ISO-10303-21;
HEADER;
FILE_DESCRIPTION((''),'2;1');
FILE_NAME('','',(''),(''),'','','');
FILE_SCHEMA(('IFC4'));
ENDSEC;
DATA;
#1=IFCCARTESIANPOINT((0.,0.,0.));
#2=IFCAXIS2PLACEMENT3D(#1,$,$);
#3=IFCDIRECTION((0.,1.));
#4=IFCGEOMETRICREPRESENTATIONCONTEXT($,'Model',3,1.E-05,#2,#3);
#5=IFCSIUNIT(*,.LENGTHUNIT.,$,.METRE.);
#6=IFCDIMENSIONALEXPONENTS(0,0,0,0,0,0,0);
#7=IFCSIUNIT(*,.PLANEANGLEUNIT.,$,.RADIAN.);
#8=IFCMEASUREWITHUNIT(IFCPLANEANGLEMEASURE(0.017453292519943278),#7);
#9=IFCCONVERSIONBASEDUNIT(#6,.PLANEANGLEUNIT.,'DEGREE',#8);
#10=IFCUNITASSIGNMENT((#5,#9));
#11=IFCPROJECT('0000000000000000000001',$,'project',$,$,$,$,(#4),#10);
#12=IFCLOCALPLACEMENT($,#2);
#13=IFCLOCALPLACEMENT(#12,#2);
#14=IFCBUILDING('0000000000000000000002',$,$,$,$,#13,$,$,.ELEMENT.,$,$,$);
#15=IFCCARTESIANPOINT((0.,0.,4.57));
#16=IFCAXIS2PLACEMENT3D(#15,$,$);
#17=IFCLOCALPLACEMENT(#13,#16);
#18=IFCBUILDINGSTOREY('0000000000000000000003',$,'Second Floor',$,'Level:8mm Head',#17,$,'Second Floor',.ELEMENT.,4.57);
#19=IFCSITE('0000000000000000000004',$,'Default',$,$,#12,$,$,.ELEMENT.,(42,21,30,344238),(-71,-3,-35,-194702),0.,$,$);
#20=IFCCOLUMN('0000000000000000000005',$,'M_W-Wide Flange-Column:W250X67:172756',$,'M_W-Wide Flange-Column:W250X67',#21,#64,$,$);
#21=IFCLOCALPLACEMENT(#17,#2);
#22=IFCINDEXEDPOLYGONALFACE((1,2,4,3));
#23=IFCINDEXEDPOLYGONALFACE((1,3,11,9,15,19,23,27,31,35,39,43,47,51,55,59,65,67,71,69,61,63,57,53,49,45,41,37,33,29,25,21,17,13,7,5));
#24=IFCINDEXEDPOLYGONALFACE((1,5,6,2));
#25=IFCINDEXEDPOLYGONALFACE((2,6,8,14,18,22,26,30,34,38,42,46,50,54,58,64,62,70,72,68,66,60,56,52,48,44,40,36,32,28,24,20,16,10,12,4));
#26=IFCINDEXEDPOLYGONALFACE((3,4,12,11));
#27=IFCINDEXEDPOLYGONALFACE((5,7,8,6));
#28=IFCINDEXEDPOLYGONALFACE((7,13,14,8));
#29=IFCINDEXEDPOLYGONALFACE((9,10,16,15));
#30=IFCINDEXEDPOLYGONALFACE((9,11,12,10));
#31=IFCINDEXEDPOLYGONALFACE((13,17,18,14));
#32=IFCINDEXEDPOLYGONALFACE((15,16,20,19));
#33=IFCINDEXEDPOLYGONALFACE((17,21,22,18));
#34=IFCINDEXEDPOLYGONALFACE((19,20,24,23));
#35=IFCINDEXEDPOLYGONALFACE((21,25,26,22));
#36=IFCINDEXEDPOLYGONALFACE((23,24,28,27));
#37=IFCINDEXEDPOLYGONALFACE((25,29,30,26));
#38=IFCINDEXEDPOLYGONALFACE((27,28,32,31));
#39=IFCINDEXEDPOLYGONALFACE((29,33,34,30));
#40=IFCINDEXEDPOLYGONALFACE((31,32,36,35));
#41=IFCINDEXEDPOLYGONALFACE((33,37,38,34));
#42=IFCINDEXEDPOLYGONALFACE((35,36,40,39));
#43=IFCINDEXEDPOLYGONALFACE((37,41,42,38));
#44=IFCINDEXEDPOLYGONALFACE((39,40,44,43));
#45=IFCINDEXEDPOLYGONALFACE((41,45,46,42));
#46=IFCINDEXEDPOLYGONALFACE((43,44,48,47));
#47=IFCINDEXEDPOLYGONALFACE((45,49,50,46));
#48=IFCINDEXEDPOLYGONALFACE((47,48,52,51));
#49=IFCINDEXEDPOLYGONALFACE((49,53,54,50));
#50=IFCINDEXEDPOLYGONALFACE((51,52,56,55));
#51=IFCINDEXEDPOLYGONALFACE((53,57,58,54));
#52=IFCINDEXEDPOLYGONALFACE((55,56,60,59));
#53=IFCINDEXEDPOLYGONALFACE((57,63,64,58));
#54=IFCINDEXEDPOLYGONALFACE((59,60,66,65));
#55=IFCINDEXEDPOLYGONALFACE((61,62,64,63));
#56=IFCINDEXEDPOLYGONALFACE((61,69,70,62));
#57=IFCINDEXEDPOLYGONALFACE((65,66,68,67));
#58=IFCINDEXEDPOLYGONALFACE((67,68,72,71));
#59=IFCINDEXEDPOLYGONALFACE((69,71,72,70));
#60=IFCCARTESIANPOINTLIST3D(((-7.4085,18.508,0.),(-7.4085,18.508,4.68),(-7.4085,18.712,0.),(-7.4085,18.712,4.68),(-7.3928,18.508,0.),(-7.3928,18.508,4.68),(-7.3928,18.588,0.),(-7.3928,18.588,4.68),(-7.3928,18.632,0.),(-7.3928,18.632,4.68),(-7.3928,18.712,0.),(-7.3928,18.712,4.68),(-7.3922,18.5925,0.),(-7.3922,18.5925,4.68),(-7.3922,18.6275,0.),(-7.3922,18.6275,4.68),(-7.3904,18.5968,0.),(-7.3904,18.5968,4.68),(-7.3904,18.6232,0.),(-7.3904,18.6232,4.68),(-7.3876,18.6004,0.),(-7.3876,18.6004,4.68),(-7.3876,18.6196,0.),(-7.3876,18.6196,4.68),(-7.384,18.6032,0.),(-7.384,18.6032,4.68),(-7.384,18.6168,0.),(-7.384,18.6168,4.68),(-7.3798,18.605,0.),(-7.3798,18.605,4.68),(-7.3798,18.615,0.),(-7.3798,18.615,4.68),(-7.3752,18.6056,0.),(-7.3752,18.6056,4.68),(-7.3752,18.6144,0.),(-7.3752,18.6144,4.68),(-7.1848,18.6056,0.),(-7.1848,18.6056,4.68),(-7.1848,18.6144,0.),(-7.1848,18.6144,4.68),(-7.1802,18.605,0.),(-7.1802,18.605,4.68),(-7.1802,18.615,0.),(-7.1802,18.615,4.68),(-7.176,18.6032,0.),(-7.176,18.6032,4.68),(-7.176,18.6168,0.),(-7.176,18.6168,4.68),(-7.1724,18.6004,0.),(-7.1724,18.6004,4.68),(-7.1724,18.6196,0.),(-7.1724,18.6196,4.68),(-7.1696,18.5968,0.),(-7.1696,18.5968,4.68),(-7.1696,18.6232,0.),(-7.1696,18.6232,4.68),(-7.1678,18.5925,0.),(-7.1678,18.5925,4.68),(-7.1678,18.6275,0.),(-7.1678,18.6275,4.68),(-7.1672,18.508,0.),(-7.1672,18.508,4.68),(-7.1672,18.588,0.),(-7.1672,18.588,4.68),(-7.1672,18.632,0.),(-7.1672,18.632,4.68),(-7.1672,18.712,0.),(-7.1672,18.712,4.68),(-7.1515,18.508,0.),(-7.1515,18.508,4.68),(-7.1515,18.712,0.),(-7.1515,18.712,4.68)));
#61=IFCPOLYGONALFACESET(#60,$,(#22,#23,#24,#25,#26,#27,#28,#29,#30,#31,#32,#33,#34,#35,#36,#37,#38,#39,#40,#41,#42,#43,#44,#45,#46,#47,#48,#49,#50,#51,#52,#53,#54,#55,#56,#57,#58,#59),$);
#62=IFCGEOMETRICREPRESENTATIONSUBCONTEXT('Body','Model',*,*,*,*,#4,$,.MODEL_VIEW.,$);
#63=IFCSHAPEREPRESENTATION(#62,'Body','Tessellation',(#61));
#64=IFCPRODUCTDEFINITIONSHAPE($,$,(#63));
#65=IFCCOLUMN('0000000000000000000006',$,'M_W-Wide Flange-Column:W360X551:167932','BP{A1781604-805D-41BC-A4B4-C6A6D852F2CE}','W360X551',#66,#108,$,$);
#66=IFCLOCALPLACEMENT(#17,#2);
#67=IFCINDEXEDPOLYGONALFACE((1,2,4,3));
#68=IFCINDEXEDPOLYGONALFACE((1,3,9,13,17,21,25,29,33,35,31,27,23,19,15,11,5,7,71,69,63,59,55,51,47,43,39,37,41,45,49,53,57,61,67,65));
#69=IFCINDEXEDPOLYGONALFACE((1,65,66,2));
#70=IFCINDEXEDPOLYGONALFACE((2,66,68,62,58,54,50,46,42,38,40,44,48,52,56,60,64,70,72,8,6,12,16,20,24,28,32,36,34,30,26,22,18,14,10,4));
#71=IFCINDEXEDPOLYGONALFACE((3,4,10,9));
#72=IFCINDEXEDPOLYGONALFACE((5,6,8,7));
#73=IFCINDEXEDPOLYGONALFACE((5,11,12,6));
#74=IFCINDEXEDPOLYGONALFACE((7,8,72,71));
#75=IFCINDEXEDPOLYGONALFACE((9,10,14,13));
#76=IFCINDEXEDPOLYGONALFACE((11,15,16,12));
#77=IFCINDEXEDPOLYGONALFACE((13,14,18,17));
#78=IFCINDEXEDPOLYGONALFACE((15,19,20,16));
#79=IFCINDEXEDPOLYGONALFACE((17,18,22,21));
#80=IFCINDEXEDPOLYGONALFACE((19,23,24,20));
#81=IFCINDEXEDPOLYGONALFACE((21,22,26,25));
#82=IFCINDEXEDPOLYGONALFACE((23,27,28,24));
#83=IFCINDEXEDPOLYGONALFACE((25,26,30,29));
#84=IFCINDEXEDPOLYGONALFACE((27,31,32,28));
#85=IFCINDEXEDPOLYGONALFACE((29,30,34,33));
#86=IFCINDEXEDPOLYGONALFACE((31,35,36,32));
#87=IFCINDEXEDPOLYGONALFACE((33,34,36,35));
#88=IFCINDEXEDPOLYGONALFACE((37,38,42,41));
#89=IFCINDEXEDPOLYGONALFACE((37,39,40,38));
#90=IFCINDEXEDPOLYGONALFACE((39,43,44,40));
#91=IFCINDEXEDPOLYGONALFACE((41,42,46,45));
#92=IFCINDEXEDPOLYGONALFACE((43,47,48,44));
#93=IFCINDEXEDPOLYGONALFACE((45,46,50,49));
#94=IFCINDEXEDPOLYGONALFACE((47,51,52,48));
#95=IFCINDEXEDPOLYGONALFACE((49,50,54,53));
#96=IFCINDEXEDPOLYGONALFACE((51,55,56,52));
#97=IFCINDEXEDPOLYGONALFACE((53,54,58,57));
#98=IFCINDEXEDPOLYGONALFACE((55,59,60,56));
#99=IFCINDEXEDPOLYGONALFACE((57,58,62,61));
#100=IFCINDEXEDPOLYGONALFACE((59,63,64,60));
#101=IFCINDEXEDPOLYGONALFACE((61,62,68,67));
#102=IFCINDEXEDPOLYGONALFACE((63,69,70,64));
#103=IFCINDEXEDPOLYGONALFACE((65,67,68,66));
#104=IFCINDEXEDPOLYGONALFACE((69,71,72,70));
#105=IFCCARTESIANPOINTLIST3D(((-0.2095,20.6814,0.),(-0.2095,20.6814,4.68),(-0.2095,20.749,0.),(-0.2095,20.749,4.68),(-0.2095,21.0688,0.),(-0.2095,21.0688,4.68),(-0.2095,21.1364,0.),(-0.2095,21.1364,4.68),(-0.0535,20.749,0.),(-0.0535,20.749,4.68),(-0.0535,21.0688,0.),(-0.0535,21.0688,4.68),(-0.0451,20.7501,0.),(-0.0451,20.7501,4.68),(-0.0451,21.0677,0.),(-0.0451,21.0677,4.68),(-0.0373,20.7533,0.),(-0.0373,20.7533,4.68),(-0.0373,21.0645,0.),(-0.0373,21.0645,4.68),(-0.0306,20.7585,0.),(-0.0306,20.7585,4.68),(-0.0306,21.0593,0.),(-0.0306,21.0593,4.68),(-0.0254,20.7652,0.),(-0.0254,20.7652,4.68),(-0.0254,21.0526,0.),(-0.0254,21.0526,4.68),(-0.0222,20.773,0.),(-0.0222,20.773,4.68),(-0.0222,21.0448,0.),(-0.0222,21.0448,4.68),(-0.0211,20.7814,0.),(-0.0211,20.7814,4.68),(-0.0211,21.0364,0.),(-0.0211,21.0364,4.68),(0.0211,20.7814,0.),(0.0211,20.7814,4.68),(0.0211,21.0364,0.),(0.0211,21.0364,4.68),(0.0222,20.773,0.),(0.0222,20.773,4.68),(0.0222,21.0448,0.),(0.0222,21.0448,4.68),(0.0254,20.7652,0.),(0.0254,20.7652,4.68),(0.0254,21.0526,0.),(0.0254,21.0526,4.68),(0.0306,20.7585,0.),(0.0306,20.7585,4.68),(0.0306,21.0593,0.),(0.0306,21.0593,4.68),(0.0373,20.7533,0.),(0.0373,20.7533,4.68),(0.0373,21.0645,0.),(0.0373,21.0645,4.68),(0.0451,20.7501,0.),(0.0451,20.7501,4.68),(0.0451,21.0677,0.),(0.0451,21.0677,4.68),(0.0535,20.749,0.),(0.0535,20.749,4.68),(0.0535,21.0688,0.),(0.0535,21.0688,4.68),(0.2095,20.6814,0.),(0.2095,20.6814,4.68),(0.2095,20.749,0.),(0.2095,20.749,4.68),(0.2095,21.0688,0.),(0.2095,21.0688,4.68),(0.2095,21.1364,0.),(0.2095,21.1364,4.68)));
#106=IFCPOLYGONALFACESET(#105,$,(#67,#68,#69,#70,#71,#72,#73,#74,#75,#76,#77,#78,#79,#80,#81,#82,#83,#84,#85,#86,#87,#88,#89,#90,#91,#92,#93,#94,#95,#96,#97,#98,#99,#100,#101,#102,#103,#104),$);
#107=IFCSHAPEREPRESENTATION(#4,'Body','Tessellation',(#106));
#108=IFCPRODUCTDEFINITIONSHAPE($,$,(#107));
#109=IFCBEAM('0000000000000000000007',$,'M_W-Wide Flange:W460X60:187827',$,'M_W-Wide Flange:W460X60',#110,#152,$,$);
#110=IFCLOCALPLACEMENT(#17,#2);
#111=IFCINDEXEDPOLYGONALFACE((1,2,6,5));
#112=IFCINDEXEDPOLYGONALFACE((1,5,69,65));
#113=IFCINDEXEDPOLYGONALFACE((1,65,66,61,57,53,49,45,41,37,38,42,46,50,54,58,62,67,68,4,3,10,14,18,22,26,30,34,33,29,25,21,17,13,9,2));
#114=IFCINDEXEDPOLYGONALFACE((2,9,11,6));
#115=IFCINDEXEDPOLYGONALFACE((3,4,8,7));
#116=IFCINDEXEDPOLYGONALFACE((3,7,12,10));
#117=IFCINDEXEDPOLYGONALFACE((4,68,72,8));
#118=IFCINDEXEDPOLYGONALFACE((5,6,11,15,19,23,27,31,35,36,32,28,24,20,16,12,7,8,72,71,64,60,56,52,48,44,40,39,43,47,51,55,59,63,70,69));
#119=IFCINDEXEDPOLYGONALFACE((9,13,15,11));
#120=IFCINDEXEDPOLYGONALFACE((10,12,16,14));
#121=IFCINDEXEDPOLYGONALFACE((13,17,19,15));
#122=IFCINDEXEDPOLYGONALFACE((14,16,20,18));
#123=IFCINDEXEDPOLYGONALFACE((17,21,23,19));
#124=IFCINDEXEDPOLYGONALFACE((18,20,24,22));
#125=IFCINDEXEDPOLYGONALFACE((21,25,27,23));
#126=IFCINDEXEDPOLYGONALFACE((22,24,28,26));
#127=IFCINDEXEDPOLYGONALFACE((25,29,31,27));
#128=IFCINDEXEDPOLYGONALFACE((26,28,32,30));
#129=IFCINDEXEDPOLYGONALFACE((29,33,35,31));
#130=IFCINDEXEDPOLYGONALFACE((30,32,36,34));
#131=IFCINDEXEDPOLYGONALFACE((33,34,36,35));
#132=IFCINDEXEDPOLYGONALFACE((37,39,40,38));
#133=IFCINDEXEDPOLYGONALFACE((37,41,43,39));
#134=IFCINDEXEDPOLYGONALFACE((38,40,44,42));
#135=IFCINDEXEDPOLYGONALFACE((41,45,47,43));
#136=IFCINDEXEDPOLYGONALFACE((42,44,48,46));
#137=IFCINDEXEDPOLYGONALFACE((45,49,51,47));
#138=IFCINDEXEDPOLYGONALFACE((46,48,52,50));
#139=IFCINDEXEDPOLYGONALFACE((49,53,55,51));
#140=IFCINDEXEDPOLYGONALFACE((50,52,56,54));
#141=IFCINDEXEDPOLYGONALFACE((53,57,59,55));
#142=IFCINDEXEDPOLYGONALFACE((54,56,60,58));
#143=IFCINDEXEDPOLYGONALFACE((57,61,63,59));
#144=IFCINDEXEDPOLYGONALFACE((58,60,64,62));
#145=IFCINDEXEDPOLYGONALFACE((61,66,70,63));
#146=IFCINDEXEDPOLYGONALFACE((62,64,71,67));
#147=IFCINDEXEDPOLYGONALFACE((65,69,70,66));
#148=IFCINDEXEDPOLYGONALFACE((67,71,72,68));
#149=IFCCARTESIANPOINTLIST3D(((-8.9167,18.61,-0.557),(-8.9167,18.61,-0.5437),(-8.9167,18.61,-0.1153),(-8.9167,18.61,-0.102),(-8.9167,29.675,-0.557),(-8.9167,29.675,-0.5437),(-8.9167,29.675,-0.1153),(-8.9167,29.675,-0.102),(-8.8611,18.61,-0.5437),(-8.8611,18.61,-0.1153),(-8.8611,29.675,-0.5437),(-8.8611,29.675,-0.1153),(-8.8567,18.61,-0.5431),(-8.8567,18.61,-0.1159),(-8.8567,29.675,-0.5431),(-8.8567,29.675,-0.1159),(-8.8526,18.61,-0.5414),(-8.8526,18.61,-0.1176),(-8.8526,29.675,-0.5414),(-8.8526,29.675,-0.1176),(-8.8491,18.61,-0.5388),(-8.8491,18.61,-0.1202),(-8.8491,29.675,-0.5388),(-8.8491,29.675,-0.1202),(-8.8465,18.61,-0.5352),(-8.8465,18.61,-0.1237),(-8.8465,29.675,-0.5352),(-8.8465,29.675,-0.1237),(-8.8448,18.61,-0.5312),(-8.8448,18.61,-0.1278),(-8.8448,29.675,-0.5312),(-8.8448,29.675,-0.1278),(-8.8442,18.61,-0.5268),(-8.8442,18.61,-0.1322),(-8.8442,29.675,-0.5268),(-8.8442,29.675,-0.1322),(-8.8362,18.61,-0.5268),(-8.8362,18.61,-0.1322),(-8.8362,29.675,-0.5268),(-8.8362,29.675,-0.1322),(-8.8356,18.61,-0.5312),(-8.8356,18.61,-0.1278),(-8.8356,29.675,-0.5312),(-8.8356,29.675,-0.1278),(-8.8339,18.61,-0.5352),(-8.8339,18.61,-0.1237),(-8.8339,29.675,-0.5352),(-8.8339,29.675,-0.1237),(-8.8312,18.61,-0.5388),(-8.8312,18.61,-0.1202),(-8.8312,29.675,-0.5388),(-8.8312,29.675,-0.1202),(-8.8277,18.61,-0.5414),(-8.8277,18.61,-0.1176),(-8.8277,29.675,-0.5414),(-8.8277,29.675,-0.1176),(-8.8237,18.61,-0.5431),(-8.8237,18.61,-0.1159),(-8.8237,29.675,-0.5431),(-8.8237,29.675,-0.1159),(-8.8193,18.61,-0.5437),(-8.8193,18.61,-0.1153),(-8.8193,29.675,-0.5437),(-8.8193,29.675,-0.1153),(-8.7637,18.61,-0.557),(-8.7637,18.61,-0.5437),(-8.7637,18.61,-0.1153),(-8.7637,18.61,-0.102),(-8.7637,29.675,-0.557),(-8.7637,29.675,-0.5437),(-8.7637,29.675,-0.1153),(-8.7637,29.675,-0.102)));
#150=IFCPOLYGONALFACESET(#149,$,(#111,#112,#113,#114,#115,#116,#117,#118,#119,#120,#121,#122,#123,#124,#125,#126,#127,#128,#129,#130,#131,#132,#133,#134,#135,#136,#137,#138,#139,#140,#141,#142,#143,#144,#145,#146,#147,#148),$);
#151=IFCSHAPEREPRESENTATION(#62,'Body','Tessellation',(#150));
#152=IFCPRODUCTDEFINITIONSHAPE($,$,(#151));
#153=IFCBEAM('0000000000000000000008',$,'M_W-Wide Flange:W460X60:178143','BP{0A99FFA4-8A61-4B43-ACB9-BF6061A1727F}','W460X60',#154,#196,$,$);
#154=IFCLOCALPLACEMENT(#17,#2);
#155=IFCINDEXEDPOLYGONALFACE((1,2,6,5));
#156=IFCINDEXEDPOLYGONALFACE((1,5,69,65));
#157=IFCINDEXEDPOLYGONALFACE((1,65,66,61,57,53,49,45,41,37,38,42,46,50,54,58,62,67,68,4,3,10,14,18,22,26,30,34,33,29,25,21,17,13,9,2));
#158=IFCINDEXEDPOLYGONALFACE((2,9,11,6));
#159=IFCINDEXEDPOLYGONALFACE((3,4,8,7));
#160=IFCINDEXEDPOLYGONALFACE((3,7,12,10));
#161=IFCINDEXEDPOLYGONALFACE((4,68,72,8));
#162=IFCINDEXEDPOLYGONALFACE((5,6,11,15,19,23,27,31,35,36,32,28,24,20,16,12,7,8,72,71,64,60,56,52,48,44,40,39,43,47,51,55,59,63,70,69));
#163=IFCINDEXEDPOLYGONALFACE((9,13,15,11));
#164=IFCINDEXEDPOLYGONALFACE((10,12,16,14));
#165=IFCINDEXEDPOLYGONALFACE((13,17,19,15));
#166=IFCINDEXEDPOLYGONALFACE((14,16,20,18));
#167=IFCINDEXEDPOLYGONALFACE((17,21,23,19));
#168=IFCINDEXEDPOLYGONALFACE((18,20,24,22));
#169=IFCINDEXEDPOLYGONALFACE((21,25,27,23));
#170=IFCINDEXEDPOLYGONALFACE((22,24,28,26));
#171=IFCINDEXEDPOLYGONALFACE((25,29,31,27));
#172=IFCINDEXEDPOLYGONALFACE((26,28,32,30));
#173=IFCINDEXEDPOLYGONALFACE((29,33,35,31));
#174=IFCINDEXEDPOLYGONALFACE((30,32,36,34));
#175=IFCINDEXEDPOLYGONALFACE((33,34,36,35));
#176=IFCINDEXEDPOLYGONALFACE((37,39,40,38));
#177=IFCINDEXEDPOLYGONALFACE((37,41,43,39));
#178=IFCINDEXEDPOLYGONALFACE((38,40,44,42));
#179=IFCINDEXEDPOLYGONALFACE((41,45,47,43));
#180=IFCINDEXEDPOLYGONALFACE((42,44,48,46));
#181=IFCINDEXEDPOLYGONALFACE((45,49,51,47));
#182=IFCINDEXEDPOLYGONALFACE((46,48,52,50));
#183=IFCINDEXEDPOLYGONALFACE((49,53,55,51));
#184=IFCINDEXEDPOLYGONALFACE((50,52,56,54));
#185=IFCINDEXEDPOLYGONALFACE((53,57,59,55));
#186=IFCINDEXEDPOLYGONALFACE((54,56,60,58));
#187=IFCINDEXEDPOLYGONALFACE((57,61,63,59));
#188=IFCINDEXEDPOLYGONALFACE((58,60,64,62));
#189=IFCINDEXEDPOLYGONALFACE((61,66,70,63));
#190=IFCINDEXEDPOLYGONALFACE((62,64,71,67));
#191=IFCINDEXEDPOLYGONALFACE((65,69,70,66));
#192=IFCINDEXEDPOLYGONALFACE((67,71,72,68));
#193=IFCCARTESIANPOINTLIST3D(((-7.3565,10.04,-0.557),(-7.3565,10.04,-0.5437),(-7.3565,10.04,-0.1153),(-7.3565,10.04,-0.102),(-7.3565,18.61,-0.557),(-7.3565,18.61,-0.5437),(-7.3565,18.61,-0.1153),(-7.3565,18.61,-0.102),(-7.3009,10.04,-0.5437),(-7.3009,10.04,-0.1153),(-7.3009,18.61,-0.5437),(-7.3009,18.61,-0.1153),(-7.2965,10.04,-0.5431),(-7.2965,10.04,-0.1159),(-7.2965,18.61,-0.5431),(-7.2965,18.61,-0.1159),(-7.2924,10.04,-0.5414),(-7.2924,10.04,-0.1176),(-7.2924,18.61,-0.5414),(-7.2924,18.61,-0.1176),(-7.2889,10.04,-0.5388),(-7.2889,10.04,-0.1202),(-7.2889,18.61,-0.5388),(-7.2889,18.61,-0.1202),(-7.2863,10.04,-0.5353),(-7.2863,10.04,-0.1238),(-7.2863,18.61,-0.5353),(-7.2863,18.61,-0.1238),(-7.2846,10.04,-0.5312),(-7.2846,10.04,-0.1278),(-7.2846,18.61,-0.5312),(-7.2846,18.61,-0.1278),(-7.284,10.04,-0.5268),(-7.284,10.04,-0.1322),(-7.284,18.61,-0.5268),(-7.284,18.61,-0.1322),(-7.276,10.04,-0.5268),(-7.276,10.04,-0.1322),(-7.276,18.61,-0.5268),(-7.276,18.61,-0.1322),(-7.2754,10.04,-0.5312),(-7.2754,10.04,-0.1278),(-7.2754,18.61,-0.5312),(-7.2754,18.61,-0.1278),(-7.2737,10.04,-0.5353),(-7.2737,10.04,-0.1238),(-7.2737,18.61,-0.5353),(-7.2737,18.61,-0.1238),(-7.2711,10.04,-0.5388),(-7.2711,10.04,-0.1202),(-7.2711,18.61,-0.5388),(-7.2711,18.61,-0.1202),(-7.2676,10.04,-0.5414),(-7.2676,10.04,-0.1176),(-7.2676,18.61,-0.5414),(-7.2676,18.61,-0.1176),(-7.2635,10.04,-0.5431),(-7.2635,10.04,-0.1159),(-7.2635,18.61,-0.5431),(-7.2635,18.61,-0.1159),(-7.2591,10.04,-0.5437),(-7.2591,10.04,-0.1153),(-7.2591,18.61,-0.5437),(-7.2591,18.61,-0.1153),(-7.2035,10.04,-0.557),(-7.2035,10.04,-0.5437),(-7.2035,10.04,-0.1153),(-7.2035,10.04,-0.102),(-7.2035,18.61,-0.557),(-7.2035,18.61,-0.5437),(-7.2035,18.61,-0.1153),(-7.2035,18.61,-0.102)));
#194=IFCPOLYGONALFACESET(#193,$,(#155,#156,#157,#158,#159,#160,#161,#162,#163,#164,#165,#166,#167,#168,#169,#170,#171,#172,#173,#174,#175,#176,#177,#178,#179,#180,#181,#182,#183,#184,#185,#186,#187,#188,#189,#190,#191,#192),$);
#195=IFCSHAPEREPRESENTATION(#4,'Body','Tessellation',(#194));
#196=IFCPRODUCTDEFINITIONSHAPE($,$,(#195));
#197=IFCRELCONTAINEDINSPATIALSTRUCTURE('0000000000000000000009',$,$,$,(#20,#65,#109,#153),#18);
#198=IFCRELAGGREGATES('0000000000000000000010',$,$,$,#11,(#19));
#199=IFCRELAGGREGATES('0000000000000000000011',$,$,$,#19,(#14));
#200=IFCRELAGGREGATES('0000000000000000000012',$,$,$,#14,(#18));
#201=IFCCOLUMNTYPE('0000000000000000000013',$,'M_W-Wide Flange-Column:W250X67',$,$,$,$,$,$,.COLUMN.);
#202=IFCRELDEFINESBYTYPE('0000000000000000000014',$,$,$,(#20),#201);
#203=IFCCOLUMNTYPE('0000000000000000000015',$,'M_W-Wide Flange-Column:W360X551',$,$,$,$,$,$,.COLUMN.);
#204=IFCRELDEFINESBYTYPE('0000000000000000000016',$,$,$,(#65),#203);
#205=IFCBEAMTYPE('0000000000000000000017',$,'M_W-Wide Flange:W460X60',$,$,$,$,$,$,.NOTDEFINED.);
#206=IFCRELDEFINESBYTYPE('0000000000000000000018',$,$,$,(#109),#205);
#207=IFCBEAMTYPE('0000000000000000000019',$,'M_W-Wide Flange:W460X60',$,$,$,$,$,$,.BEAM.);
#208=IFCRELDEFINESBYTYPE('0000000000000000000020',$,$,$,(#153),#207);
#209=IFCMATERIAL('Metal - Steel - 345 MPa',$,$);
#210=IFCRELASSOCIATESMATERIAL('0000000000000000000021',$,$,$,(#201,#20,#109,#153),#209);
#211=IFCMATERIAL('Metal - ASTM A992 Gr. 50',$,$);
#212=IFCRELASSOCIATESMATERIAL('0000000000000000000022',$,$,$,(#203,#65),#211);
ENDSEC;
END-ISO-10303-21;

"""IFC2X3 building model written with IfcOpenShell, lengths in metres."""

from ifc_helpers import new_model, entity, si_unit, converted_unit, direction, frame, frame_2d, origin, origin_2d, place, context, subcontext, project, spatial, i_section, extrude, source, transform, mapped, material, type_object, type_shapes, element, save


model = new_model("IFC2X3")

# Units and contexts
model_context = context("Model", 3, precision=1e-05, world=origin(), true_north=direction((0.0, 1.0)))
body_context = subcontext(model_context, "Body", "Model", "MODEL_VIEW")
ifc_project = project(units=[si_unit("LENGTHUNIT", "METRE"), converted_unit("PLANEANGLEUNIT", "DEGREE", entity("IfcPlaneAngleMeasure", 0.017453292519943278), si_unit("PLANEANGLEUNIT", "RADIAN"), dimensions=[0, 0, 0, 0, 0, 0, 0])], contexts=[model_context])

# Site, building, storey
site_placement = place(None, origin())
site = spatial("IfcSite", under=ifc_project, at=site_placement, Name="Default", CompositionType="ELEMENT", RefLatitude=(42, 21, 30, 344238), RefLongitude=(-71, -3, -35, -194702), RefElevation=0.0)
building_placement = place(site_placement, origin())
building = spatial("IfcBuilding", under=site, at=building_placement, CompositionType="ELEMENT")
storey_placement = place(building_placement, frame((0.0, 0.0, 4.57)))
storey = spatial("IfcBuildingStorey", under=building, at=storey_placement, Name="Second Floor", ObjectType="Level:8mm Head", LongName="Second Floor", CompositionType="ELEMENT", Elevation=4.57)

# Columns
ifc_material_1 = material(Name="Metal - Steel - 345 MPa")
column_type_1 = type_object("IfcColumnType", Name="M_W-Wide Flange-Column:W250X67", PredefinedType="COLUMN", material=ifc_material_1)
shared_shape_1 = source(origin(), body_context, "Body", "SweptSolid", [
    extrude(i_section(OverallWidth=0.204, OverallDepth=0.257, WebThickness=0.0089, FlangeThickness=0.0157, FilletRadius=0.0176, at=frame_2d((0.0, 0.0), x_axis=(1.0, 0.0))), frame((0.0, 0.0, 4.57), z_axis=(0.0, 0.0, 1.0), x_axis=(-1.0, 0.0, 0.0)), (0.0, 0.0, 1.0), 4.68),
])
type_shapes(column_type_1, [shared_shape_1])
column_1_placement = place(storey_placement, frame((-7.28, 18.61, -4.57), z_axis=(0.0, 0.0, 1.0), x_axis=(0.0, 1.0, 0.0)))
element("IfcColumn", 1, at=column_1_placement, inside=storey, type_object=column_type_1, material=ifc_material_1, Name="M_W-Wide Flange-Column:W250X67:172756", ObjectType="M_W-Wide Flange-Column:W250X67", context=body_context, shape_type="MappedRepresentation", body=[
    mapped(shared_shape_1, transform((0.0, 0.0, 0.0), scale=1.0)),
])
ifc_material_2 = material(Name="Metal - ASTM A992 Gr. 50")
column_type_2 = type_object("IfcColumnType", Name="M_W-Wide Flange-Column:W360X551", PredefinedType="COLUMN", material=ifc_material_2)
column_2_placement = place(storey_placement, frame((0.0, 20.9089, 4.68), z_axis=(0.0, 0.0, 1.0), x_axis=(-1.0, 0.0, 0.0)))
element("IfcColumn", 2, at=column_2_placement, inside=storey, type_object=column_type_2, material=ifc_material_2, Name="M_W-Wide Flange-Column:W360X551:167932", Description="BP{A1781604-805D-41BC-A4B4-C6A6D852F2CE}", ObjectType="W360X551", context=model_context, shape_type="SweptSolid", body=[
    extrude(i_section(OverallWidth=0.419, OverallDepth=0.455, WebThickness=0.0422, FlangeThickness=0.0676, FilletRadius=0.0324, at=origin_2d()), origin(), (0.0, 0.0, -1.0), 4.68),
])

# Beams
beam_type_1 = type_object("IfcBeamType", Name="M_W-Wide Flange:W460X60", PredefinedType="NOTDEFINED")
beam_1_placement = place(storey_placement, frame((-8.8402, 18.61, -0.102), z_axis=(0.0, 0.0, 1.0), x_axis=(0.0, 1.0, 0.0)))
element("IfcBeam", 3, at=beam_1_placement, inside=storey, type_object=beam_type_1, material=ifc_material_1, Name="M_W-Wide Flange:W460X60:187827", ObjectType="M_W-Wide Flange:W460X60", context=body_context, shape_type="SweptSolid", body=[
    extrude(i_section(OverallWidth=0.153, OverallDepth=0.455, WebThickness=0.008, FlangeThickness=0.0133, FilletRadius=0.0169, at=frame_2d((0.0, 0.0), x_axis=(0.0, 1.0))), frame((0.0, 0.0, -0.2275), z_axis=(1.0, 0.0, 0.0), x_axis=(0.0, 0.0, -1.0)), (0.0, 0.0, 1.0), 11.065),
])
beam_type_2 = type_object("IfcBeamType", Name="M_W-Wide Flange:W460X60", PredefinedType="BEAM")
beam_2_placement = place(storey_placement, frame((-7.28, 18.61, -0.3295), z_axis=(0.0, 1.0, 0.0), x_axis=(-1.0, 0.0, 0.0)))
element("IfcBeam", 4, at=beam_2_placement, inside=storey, type_object=beam_type_2, material=ifc_material_1, Name="M_W-Wide Flange:W460X60:178143", Description="BP{0A99FFA4-8A61-4B43-ACB9-BF6061A1727F}", ObjectType="W460X60", context=model_context, shape_type="SweptSolid", body=[
    extrude(i_section(OverallWidth=0.153, OverallDepth=0.455, WebThickness=0.008, FlangeThickness=0.0133, FilletRadius=0.0169, at=origin_2d()), origin(), (0.0, 0.0, -1.0), 8.57),
])

save(model, "model.ifc")
